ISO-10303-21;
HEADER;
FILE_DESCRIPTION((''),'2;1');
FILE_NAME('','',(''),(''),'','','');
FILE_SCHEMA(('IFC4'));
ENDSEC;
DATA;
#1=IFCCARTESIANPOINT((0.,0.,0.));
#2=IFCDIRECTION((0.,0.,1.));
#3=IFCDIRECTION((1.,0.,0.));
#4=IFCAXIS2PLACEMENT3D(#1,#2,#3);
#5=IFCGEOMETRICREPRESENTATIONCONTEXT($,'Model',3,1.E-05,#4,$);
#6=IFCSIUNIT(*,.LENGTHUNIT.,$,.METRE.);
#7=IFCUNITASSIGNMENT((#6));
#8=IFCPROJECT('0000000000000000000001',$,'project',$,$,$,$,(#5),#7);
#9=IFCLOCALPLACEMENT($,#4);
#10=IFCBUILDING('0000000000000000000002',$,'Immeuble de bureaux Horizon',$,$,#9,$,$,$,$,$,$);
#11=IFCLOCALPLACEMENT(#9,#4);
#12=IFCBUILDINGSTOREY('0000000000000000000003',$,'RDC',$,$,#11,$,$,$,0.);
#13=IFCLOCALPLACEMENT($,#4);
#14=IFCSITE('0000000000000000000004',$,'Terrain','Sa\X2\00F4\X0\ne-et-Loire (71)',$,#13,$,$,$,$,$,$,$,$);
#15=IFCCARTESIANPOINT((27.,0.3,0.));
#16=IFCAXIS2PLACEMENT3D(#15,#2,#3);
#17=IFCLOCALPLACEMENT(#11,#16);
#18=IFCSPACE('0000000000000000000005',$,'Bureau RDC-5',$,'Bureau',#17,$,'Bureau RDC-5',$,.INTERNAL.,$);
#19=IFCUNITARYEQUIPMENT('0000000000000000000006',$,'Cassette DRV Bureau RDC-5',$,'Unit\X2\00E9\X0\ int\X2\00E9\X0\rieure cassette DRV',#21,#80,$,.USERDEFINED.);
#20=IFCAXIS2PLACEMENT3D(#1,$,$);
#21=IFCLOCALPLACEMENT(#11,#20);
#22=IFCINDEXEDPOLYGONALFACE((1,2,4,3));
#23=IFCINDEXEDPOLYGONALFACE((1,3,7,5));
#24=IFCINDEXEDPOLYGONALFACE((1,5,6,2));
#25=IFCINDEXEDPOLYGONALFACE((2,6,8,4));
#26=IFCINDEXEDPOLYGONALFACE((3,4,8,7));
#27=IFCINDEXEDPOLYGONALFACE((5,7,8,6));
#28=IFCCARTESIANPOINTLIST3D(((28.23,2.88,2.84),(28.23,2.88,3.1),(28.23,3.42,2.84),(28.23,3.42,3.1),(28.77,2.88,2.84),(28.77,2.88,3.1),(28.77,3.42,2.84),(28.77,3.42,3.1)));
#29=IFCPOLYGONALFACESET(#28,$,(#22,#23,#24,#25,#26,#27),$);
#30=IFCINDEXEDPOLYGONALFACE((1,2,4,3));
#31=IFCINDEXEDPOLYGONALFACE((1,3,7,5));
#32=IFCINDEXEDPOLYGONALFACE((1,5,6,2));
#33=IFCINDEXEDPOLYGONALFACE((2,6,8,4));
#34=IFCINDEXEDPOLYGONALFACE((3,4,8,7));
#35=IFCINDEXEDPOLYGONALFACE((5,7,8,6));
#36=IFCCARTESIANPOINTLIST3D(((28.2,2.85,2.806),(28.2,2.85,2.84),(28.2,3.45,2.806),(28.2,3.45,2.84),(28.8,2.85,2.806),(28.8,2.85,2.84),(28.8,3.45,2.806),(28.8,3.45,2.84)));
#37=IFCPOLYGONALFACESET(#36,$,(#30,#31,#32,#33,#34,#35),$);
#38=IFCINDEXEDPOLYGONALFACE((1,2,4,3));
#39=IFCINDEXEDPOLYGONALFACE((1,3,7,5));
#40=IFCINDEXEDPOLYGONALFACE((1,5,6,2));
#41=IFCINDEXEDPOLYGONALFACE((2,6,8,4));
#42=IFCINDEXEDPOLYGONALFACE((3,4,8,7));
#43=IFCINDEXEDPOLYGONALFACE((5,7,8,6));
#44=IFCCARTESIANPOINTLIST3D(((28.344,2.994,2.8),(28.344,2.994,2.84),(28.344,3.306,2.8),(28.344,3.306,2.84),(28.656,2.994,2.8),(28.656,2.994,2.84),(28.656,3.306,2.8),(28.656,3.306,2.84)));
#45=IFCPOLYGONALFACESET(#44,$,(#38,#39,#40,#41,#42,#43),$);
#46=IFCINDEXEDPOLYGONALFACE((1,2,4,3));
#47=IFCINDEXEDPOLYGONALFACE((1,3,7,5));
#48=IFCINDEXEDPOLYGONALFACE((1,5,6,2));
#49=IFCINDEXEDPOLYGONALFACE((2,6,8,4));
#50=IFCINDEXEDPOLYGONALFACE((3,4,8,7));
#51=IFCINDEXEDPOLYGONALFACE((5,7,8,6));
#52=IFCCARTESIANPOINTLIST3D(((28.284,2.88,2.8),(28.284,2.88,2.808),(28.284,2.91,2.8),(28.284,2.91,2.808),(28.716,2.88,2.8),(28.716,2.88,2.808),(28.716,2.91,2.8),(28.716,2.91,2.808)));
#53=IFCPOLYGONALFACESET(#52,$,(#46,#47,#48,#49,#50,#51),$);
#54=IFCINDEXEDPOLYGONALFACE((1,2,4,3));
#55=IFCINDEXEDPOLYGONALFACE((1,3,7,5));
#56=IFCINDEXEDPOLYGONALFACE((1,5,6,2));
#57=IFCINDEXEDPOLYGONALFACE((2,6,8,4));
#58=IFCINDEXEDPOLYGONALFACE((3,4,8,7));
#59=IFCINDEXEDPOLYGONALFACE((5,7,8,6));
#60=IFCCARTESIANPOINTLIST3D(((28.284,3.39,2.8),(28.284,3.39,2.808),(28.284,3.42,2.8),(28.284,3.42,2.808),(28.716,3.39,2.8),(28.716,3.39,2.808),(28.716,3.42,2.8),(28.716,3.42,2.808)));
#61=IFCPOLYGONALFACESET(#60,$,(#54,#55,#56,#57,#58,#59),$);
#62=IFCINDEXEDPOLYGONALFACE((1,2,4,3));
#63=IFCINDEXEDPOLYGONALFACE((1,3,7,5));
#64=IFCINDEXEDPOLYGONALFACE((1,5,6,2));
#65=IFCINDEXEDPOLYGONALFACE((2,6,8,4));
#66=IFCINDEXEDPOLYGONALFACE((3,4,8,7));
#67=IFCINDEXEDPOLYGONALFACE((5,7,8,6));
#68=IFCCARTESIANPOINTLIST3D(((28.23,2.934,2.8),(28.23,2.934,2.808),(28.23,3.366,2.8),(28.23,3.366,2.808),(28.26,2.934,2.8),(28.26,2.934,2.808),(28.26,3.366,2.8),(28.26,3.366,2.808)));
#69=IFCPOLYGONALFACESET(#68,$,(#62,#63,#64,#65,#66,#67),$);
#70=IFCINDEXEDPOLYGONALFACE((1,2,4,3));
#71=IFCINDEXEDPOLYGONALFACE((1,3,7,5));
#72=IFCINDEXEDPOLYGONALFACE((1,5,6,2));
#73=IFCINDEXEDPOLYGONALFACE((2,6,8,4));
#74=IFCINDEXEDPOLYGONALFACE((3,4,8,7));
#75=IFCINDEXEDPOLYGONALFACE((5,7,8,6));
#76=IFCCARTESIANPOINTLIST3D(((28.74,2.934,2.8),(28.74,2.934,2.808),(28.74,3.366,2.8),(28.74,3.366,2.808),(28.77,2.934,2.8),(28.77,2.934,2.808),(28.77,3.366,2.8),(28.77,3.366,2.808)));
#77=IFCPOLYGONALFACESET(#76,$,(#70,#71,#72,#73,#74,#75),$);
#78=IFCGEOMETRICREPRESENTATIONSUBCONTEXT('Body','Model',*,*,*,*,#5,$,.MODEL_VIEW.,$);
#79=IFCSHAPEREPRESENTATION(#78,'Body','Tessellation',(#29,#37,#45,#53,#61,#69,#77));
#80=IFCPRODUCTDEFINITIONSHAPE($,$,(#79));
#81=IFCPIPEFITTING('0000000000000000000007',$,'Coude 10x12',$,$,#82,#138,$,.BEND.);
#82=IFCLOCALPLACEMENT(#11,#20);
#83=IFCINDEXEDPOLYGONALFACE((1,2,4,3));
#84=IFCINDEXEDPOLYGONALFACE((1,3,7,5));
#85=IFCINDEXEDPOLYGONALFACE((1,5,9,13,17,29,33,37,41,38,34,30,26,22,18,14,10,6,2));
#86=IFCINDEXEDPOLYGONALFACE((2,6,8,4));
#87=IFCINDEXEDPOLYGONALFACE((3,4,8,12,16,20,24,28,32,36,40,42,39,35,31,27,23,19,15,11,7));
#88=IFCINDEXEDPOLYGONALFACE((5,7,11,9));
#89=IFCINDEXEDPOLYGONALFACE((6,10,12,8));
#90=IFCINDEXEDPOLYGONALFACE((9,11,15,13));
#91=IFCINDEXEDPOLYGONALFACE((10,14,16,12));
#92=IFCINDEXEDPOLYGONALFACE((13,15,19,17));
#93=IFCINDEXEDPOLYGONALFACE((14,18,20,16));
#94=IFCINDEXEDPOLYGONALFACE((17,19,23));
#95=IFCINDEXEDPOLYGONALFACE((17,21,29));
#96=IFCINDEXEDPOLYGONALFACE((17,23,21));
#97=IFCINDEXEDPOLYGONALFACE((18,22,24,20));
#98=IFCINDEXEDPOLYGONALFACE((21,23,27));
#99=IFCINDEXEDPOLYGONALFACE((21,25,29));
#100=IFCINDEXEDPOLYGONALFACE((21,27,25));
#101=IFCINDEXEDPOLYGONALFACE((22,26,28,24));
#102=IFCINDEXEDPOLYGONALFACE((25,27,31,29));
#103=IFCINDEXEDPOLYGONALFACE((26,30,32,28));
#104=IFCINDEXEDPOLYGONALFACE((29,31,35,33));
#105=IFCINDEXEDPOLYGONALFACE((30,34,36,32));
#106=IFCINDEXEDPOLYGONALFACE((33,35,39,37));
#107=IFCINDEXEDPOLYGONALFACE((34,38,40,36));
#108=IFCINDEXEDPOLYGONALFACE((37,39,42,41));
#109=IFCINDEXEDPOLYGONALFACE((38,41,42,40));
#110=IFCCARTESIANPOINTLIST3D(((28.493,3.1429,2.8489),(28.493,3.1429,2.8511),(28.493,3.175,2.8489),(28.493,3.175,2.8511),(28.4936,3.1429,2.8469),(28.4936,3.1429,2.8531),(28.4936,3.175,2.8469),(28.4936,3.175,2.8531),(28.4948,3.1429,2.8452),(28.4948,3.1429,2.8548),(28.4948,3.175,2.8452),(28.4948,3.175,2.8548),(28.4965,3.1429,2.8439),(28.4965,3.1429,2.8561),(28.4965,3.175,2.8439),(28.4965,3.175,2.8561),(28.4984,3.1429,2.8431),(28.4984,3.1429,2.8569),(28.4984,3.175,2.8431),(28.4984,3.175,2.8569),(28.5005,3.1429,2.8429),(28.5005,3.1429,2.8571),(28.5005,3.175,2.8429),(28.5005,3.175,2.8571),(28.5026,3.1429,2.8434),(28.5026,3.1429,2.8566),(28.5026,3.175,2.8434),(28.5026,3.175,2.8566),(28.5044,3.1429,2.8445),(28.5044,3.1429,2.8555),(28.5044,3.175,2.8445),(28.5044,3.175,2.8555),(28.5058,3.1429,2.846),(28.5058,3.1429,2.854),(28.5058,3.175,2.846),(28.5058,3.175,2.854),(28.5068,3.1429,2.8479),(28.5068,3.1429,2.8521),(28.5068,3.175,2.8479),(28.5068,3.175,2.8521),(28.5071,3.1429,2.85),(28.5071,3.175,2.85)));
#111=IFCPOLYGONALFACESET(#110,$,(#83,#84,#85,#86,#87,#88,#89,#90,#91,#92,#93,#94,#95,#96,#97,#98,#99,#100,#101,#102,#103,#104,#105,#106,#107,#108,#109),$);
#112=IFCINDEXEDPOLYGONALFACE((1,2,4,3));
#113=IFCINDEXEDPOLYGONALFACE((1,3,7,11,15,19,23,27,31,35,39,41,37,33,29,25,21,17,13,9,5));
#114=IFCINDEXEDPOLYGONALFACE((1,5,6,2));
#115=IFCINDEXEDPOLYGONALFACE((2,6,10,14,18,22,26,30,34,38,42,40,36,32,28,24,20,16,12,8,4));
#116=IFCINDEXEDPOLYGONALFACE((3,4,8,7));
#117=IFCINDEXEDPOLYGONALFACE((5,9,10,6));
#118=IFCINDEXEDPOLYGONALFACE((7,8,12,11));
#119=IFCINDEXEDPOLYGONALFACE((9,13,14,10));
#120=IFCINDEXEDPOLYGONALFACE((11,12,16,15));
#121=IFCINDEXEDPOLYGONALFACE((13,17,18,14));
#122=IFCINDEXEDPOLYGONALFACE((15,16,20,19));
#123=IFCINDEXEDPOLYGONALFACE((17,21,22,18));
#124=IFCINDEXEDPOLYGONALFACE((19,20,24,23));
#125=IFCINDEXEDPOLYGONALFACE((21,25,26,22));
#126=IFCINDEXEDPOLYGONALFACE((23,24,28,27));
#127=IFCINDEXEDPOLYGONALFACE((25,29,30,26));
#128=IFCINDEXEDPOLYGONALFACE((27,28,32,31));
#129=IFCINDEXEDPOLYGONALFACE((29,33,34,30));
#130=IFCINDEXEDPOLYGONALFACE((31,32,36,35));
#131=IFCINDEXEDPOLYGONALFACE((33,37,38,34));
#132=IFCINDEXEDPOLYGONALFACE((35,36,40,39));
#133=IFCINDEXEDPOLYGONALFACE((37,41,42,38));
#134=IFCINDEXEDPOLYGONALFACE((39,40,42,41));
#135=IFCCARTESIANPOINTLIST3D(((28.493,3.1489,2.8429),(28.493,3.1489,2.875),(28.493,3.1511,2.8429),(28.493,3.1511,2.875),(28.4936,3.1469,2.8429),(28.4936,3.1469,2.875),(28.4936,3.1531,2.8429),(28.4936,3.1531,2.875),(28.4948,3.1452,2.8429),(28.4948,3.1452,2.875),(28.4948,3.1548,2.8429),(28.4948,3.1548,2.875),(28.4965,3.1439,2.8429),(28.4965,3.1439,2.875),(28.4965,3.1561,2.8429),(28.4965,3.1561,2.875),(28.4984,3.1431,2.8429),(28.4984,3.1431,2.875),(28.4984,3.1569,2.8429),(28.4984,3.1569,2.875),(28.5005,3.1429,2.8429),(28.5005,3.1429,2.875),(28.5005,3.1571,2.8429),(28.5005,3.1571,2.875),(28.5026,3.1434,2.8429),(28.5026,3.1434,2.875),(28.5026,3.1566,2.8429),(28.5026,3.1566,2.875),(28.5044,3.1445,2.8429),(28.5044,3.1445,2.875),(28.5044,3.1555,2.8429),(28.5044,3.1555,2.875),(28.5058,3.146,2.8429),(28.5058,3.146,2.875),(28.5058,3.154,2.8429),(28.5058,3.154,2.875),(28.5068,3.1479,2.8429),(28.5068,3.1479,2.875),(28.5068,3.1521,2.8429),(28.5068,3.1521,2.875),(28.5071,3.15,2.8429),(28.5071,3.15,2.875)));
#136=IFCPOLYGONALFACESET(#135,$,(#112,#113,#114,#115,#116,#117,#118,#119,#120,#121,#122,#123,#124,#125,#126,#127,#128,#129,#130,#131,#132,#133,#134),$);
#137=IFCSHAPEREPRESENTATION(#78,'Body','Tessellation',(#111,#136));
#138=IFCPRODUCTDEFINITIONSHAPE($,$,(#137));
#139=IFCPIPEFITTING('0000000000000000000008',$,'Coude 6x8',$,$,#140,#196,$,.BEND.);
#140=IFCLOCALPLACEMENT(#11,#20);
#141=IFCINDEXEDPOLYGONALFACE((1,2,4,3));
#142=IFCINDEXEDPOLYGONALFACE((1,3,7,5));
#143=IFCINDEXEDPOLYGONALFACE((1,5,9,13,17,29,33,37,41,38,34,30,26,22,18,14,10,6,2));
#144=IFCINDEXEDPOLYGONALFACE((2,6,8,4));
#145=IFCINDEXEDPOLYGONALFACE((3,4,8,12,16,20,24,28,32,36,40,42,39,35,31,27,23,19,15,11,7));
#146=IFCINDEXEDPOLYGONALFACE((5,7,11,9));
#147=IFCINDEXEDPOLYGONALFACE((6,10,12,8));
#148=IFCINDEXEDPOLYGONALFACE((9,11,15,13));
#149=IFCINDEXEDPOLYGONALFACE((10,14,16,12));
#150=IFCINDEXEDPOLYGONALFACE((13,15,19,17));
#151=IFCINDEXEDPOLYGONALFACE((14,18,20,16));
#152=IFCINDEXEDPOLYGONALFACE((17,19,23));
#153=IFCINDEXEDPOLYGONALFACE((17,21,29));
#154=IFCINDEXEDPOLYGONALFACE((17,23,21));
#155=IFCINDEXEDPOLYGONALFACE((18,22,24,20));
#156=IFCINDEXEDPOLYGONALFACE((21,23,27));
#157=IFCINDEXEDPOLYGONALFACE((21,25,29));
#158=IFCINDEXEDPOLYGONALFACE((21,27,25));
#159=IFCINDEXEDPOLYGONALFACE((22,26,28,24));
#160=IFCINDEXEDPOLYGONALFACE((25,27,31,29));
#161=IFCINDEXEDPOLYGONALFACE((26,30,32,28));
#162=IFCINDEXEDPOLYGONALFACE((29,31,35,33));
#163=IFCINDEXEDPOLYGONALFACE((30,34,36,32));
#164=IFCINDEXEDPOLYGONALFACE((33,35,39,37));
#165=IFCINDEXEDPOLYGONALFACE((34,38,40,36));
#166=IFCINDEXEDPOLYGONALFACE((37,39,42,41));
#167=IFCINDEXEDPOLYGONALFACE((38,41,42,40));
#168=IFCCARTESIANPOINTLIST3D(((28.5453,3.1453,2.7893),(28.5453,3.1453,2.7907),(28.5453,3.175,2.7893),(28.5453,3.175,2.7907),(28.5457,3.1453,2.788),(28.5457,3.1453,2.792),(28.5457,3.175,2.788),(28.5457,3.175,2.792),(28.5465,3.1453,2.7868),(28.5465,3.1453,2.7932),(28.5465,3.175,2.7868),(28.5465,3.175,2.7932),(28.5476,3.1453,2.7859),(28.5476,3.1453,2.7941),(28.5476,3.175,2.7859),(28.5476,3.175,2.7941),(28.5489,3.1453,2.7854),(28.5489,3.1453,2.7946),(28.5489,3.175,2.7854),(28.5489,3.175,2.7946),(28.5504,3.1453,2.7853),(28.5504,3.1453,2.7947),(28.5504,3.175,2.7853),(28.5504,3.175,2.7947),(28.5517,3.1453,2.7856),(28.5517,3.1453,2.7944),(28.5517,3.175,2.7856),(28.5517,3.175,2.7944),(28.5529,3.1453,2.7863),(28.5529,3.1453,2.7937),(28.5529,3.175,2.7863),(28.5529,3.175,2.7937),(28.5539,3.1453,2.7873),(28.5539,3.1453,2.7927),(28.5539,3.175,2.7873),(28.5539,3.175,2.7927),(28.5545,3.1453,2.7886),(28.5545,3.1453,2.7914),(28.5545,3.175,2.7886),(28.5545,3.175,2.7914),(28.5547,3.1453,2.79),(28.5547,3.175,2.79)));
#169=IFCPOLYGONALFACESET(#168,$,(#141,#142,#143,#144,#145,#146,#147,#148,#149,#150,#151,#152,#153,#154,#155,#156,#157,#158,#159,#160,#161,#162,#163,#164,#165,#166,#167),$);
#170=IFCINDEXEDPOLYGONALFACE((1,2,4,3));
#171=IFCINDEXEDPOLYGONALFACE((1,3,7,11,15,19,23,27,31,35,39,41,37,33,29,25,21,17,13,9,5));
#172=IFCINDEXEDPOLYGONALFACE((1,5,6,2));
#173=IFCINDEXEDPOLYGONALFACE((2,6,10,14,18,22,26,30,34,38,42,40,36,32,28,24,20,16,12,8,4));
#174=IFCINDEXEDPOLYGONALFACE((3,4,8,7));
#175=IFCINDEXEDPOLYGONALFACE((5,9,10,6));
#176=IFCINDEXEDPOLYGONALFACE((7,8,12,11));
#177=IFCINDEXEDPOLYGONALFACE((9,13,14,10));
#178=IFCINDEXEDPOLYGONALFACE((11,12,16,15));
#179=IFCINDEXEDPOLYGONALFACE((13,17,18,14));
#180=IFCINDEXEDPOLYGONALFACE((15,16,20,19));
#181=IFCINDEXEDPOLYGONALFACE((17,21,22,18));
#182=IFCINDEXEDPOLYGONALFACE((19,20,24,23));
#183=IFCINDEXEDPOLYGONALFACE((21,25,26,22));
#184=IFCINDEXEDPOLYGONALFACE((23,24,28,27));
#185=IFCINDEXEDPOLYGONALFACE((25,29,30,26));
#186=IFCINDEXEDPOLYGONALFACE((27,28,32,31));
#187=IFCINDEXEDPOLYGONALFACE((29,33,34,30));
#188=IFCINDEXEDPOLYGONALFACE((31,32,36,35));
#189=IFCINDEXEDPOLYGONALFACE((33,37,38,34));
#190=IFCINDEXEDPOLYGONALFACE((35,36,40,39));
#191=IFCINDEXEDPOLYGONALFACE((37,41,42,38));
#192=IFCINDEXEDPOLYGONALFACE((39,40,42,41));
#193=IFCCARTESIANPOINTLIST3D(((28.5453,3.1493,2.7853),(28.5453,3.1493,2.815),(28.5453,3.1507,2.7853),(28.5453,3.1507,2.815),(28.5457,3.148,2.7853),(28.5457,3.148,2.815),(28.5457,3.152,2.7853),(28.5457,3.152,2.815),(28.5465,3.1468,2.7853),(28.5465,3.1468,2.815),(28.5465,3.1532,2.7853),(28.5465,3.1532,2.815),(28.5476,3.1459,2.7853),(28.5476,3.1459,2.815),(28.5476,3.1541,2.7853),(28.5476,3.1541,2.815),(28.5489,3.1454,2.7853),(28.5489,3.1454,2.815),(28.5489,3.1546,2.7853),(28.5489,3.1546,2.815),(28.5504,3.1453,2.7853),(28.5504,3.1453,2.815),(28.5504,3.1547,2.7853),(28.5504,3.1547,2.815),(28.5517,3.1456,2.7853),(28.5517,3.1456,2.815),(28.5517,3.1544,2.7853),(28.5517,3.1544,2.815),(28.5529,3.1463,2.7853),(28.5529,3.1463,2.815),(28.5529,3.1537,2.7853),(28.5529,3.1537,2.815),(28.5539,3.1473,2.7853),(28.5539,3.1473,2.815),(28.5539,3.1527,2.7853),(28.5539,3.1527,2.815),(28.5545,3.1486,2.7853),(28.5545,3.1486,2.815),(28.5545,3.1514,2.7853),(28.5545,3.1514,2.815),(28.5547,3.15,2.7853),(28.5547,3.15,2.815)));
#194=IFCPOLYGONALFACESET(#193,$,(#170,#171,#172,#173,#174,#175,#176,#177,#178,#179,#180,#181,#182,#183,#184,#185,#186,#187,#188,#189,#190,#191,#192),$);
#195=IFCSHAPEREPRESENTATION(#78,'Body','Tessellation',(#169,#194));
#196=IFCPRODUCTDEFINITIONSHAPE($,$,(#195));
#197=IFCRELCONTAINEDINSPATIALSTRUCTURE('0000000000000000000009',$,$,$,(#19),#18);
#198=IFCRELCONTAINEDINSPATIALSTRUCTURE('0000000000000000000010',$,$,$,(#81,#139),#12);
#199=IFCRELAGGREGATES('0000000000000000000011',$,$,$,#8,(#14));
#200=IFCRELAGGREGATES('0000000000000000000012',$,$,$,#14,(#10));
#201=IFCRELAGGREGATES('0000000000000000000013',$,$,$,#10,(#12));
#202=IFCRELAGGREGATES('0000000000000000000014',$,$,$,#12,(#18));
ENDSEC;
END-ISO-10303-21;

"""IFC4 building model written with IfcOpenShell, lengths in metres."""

from ifc_helpers import new_model, si_unit, frame, frame_2d, origin_with_axes, place, context, subcontext, project, spatial, rectangle, circle, extrude, element, save


model = new_model("IFC4")

# Units and contexts
model_context = context("Model", 3, precision=1e-05, world=origin_with_axes())
body_context = subcontext(model_context, "Body", "Model", "MODEL_VIEW")
ifc_project = project(units=[si_unit("LENGTHUNIT", "METRE")], contexts=[model_context])

# Site, building, storey
site_placement = place(None, origin_with_axes())
site = spatial("IfcSite", under=ifc_project, at=site_placement, Name="Terrain", Description="Saône-et-Loire (71)")
building_placement = place(None, origin_with_axes())
building = spatial("IfcBuilding", under=site, at=building_placement, Name="Immeuble de bureaux Horizon")
storey_placement = place(building_placement, origin_with_axes())
storey = spatial("IfcBuildingStorey", under=building, at=storey_placement, Name="RDC", Elevation=0.0)

# Shared definitions
space_placement = place(storey_placement, frame((27.0, 0.3, 0.0), z_axis=(0.0, 0.0, 1.0), x_axis=(1.0, 0.0, 0.0)))
space = spatial("IfcSpace", under=storey, at=space_placement, Name="Bureau RDC-5", ObjectType="Bureau", LongName="Bureau RDC-5", PredefinedType="INTERNAL")

# Unitary equipment
unitary_equipment_placement = place(space_placement, frame((1.2, 2.55, 2.8), z_axis=(0.0, 0.0, 1.0), x_axis=(1.0, 0.0, 0.0)))
element("IfcUnitaryEquipment", 1, at=unitary_equipment_placement, inside=space, Name="Cassette DRV Bureau RDC-5", ObjectType="Unité intérieure cassette DRV", PredefinedType="USERDEFINED", context=body_context, shape_type="SweptSolid", body=[
    extrude(rectangle(XDim=0.54, YDim=0.54, at=frame_2d((0.27, 0.27))), frame((0.03, 0.03, 0.04), z_axis=(0.0, 0.0, 1.0), x_axis=(1.0, 0.0, 0.0)), (0.0, 0.0, 1.0), 0.26),
    extrude(rectangle(XDim=0.6, YDim=0.6, at=frame_2d((0.3, 0.3))), frame((0.0, 0.0, 0.006), z_axis=(0.0, 0.0, 1.0), x_axis=(1.0, 0.0, 0.0)), (0.0, 0.0, 1.0), 0.034),
    extrude(rectangle(XDim=0.312, YDim=0.312, at=frame_2d((0.156, 0.156))), frame((0.144, 0.144, 0.0), z_axis=(0.0, 0.0, 1.0), x_axis=(1.0, 0.0, 0.0)), (0.0, 0.0, 1.0), 0.04),
    extrude(rectangle(XDim=0.432, YDim=0.03, at=frame_2d((0.216, 0.015))), frame((0.084, 0.03, 0.0), z_axis=(0.0, 0.0, 1.0), x_axis=(1.0, 0.0, 0.0)), (0.0, 0.0, 1.0), 0.008),
    extrude(rectangle(XDim=0.432, YDim=0.03, at=frame_2d((0.216, 0.015))), frame((0.084, 0.54, 0.0), z_axis=(0.0, 0.0, 1.0), x_axis=(1.0, 0.0, 0.0)), (0.0, 0.0, 1.0), 0.008),
    extrude(rectangle(XDim=0.03, YDim=0.432, at=frame_2d((0.015, 0.216))), frame((0.03, 0.084, 0.0), z_axis=(0.0, 0.0, 1.0), x_axis=(1.0, 0.0, 0.0)), (0.0, 0.0, 1.0), 0.008),
    extrude(rectangle(XDim=0.03, YDim=0.432, at=frame_2d((0.015, 0.216))), frame((0.54, 0.084, 0.0), z_axis=(0.0, 0.0, 1.0), x_axis=(1.0, 0.0, 0.0)), (0.0, 0.0, 1.0), 0.008),
])

# Pipe fittings
pipe_fitting_1_placement = place(storey_placement, frame((28.5, 3.15, 2.85), z_axis=(0.0, 0.0, 1.0), x_axis=(1.0, 0.0, 0.0)))
element("IfcPipeFitting", 2, at=pipe_fitting_1_placement, inside=storey, Name="Coude 10x12", PredefinedType="BEND", context=body_context, shape_type="SweptSolid", body=[
    extrude(circle(Radius=0.0071), frame((0.0, -0.0071, 0.0), z_axis=(0.0, 1.0, 0.0), x_axis=(1.0, 0.0, 0.0)), (0.0, 0.0, 1.0), 0.0321),
    extrude(circle(Radius=0.0071), frame((0.0, 0.0, -0.0071), z_axis=(0.0, 0.0, 1.0), x_axis=(1.0, 0.0, 0.0)), (0.0, 0.0, 1.0), 0.0321),
])
pipe_fitting_2_placement = place(storey_placement, frame((28.55, 3.15, 2.79), z_axis=(0.0, 0.0, 1.0), x_axis=(1.0, 0.0, 0.0)))
element("IfcPipeFitting", 3, at=pipe_fitting_2_placement, inside=storey, Name="Coude 6x8", PredefinedType="BEND", context=body_context, shape_type="SweptSolid", body=[
    extrude(circle(Radius=0.0047), frame((0.0, -0.0047, 0.0), z_axis=(0.0, 1.0, 0.0), x_axis=(1.0, 0.0, 0.0)), (0.0, 0.0, 1.0), 0.0297),
    extrude(circle(Radius=0.0047), frame((0.0, 0.0, -0.0047), z_axis=(0.0, 0.0, 1.0), x_axis=(1.0, 0.0, 0.0)), (0.0, 0.0, 1.0), 0.0297),
])

save(model, "model.ifc")
